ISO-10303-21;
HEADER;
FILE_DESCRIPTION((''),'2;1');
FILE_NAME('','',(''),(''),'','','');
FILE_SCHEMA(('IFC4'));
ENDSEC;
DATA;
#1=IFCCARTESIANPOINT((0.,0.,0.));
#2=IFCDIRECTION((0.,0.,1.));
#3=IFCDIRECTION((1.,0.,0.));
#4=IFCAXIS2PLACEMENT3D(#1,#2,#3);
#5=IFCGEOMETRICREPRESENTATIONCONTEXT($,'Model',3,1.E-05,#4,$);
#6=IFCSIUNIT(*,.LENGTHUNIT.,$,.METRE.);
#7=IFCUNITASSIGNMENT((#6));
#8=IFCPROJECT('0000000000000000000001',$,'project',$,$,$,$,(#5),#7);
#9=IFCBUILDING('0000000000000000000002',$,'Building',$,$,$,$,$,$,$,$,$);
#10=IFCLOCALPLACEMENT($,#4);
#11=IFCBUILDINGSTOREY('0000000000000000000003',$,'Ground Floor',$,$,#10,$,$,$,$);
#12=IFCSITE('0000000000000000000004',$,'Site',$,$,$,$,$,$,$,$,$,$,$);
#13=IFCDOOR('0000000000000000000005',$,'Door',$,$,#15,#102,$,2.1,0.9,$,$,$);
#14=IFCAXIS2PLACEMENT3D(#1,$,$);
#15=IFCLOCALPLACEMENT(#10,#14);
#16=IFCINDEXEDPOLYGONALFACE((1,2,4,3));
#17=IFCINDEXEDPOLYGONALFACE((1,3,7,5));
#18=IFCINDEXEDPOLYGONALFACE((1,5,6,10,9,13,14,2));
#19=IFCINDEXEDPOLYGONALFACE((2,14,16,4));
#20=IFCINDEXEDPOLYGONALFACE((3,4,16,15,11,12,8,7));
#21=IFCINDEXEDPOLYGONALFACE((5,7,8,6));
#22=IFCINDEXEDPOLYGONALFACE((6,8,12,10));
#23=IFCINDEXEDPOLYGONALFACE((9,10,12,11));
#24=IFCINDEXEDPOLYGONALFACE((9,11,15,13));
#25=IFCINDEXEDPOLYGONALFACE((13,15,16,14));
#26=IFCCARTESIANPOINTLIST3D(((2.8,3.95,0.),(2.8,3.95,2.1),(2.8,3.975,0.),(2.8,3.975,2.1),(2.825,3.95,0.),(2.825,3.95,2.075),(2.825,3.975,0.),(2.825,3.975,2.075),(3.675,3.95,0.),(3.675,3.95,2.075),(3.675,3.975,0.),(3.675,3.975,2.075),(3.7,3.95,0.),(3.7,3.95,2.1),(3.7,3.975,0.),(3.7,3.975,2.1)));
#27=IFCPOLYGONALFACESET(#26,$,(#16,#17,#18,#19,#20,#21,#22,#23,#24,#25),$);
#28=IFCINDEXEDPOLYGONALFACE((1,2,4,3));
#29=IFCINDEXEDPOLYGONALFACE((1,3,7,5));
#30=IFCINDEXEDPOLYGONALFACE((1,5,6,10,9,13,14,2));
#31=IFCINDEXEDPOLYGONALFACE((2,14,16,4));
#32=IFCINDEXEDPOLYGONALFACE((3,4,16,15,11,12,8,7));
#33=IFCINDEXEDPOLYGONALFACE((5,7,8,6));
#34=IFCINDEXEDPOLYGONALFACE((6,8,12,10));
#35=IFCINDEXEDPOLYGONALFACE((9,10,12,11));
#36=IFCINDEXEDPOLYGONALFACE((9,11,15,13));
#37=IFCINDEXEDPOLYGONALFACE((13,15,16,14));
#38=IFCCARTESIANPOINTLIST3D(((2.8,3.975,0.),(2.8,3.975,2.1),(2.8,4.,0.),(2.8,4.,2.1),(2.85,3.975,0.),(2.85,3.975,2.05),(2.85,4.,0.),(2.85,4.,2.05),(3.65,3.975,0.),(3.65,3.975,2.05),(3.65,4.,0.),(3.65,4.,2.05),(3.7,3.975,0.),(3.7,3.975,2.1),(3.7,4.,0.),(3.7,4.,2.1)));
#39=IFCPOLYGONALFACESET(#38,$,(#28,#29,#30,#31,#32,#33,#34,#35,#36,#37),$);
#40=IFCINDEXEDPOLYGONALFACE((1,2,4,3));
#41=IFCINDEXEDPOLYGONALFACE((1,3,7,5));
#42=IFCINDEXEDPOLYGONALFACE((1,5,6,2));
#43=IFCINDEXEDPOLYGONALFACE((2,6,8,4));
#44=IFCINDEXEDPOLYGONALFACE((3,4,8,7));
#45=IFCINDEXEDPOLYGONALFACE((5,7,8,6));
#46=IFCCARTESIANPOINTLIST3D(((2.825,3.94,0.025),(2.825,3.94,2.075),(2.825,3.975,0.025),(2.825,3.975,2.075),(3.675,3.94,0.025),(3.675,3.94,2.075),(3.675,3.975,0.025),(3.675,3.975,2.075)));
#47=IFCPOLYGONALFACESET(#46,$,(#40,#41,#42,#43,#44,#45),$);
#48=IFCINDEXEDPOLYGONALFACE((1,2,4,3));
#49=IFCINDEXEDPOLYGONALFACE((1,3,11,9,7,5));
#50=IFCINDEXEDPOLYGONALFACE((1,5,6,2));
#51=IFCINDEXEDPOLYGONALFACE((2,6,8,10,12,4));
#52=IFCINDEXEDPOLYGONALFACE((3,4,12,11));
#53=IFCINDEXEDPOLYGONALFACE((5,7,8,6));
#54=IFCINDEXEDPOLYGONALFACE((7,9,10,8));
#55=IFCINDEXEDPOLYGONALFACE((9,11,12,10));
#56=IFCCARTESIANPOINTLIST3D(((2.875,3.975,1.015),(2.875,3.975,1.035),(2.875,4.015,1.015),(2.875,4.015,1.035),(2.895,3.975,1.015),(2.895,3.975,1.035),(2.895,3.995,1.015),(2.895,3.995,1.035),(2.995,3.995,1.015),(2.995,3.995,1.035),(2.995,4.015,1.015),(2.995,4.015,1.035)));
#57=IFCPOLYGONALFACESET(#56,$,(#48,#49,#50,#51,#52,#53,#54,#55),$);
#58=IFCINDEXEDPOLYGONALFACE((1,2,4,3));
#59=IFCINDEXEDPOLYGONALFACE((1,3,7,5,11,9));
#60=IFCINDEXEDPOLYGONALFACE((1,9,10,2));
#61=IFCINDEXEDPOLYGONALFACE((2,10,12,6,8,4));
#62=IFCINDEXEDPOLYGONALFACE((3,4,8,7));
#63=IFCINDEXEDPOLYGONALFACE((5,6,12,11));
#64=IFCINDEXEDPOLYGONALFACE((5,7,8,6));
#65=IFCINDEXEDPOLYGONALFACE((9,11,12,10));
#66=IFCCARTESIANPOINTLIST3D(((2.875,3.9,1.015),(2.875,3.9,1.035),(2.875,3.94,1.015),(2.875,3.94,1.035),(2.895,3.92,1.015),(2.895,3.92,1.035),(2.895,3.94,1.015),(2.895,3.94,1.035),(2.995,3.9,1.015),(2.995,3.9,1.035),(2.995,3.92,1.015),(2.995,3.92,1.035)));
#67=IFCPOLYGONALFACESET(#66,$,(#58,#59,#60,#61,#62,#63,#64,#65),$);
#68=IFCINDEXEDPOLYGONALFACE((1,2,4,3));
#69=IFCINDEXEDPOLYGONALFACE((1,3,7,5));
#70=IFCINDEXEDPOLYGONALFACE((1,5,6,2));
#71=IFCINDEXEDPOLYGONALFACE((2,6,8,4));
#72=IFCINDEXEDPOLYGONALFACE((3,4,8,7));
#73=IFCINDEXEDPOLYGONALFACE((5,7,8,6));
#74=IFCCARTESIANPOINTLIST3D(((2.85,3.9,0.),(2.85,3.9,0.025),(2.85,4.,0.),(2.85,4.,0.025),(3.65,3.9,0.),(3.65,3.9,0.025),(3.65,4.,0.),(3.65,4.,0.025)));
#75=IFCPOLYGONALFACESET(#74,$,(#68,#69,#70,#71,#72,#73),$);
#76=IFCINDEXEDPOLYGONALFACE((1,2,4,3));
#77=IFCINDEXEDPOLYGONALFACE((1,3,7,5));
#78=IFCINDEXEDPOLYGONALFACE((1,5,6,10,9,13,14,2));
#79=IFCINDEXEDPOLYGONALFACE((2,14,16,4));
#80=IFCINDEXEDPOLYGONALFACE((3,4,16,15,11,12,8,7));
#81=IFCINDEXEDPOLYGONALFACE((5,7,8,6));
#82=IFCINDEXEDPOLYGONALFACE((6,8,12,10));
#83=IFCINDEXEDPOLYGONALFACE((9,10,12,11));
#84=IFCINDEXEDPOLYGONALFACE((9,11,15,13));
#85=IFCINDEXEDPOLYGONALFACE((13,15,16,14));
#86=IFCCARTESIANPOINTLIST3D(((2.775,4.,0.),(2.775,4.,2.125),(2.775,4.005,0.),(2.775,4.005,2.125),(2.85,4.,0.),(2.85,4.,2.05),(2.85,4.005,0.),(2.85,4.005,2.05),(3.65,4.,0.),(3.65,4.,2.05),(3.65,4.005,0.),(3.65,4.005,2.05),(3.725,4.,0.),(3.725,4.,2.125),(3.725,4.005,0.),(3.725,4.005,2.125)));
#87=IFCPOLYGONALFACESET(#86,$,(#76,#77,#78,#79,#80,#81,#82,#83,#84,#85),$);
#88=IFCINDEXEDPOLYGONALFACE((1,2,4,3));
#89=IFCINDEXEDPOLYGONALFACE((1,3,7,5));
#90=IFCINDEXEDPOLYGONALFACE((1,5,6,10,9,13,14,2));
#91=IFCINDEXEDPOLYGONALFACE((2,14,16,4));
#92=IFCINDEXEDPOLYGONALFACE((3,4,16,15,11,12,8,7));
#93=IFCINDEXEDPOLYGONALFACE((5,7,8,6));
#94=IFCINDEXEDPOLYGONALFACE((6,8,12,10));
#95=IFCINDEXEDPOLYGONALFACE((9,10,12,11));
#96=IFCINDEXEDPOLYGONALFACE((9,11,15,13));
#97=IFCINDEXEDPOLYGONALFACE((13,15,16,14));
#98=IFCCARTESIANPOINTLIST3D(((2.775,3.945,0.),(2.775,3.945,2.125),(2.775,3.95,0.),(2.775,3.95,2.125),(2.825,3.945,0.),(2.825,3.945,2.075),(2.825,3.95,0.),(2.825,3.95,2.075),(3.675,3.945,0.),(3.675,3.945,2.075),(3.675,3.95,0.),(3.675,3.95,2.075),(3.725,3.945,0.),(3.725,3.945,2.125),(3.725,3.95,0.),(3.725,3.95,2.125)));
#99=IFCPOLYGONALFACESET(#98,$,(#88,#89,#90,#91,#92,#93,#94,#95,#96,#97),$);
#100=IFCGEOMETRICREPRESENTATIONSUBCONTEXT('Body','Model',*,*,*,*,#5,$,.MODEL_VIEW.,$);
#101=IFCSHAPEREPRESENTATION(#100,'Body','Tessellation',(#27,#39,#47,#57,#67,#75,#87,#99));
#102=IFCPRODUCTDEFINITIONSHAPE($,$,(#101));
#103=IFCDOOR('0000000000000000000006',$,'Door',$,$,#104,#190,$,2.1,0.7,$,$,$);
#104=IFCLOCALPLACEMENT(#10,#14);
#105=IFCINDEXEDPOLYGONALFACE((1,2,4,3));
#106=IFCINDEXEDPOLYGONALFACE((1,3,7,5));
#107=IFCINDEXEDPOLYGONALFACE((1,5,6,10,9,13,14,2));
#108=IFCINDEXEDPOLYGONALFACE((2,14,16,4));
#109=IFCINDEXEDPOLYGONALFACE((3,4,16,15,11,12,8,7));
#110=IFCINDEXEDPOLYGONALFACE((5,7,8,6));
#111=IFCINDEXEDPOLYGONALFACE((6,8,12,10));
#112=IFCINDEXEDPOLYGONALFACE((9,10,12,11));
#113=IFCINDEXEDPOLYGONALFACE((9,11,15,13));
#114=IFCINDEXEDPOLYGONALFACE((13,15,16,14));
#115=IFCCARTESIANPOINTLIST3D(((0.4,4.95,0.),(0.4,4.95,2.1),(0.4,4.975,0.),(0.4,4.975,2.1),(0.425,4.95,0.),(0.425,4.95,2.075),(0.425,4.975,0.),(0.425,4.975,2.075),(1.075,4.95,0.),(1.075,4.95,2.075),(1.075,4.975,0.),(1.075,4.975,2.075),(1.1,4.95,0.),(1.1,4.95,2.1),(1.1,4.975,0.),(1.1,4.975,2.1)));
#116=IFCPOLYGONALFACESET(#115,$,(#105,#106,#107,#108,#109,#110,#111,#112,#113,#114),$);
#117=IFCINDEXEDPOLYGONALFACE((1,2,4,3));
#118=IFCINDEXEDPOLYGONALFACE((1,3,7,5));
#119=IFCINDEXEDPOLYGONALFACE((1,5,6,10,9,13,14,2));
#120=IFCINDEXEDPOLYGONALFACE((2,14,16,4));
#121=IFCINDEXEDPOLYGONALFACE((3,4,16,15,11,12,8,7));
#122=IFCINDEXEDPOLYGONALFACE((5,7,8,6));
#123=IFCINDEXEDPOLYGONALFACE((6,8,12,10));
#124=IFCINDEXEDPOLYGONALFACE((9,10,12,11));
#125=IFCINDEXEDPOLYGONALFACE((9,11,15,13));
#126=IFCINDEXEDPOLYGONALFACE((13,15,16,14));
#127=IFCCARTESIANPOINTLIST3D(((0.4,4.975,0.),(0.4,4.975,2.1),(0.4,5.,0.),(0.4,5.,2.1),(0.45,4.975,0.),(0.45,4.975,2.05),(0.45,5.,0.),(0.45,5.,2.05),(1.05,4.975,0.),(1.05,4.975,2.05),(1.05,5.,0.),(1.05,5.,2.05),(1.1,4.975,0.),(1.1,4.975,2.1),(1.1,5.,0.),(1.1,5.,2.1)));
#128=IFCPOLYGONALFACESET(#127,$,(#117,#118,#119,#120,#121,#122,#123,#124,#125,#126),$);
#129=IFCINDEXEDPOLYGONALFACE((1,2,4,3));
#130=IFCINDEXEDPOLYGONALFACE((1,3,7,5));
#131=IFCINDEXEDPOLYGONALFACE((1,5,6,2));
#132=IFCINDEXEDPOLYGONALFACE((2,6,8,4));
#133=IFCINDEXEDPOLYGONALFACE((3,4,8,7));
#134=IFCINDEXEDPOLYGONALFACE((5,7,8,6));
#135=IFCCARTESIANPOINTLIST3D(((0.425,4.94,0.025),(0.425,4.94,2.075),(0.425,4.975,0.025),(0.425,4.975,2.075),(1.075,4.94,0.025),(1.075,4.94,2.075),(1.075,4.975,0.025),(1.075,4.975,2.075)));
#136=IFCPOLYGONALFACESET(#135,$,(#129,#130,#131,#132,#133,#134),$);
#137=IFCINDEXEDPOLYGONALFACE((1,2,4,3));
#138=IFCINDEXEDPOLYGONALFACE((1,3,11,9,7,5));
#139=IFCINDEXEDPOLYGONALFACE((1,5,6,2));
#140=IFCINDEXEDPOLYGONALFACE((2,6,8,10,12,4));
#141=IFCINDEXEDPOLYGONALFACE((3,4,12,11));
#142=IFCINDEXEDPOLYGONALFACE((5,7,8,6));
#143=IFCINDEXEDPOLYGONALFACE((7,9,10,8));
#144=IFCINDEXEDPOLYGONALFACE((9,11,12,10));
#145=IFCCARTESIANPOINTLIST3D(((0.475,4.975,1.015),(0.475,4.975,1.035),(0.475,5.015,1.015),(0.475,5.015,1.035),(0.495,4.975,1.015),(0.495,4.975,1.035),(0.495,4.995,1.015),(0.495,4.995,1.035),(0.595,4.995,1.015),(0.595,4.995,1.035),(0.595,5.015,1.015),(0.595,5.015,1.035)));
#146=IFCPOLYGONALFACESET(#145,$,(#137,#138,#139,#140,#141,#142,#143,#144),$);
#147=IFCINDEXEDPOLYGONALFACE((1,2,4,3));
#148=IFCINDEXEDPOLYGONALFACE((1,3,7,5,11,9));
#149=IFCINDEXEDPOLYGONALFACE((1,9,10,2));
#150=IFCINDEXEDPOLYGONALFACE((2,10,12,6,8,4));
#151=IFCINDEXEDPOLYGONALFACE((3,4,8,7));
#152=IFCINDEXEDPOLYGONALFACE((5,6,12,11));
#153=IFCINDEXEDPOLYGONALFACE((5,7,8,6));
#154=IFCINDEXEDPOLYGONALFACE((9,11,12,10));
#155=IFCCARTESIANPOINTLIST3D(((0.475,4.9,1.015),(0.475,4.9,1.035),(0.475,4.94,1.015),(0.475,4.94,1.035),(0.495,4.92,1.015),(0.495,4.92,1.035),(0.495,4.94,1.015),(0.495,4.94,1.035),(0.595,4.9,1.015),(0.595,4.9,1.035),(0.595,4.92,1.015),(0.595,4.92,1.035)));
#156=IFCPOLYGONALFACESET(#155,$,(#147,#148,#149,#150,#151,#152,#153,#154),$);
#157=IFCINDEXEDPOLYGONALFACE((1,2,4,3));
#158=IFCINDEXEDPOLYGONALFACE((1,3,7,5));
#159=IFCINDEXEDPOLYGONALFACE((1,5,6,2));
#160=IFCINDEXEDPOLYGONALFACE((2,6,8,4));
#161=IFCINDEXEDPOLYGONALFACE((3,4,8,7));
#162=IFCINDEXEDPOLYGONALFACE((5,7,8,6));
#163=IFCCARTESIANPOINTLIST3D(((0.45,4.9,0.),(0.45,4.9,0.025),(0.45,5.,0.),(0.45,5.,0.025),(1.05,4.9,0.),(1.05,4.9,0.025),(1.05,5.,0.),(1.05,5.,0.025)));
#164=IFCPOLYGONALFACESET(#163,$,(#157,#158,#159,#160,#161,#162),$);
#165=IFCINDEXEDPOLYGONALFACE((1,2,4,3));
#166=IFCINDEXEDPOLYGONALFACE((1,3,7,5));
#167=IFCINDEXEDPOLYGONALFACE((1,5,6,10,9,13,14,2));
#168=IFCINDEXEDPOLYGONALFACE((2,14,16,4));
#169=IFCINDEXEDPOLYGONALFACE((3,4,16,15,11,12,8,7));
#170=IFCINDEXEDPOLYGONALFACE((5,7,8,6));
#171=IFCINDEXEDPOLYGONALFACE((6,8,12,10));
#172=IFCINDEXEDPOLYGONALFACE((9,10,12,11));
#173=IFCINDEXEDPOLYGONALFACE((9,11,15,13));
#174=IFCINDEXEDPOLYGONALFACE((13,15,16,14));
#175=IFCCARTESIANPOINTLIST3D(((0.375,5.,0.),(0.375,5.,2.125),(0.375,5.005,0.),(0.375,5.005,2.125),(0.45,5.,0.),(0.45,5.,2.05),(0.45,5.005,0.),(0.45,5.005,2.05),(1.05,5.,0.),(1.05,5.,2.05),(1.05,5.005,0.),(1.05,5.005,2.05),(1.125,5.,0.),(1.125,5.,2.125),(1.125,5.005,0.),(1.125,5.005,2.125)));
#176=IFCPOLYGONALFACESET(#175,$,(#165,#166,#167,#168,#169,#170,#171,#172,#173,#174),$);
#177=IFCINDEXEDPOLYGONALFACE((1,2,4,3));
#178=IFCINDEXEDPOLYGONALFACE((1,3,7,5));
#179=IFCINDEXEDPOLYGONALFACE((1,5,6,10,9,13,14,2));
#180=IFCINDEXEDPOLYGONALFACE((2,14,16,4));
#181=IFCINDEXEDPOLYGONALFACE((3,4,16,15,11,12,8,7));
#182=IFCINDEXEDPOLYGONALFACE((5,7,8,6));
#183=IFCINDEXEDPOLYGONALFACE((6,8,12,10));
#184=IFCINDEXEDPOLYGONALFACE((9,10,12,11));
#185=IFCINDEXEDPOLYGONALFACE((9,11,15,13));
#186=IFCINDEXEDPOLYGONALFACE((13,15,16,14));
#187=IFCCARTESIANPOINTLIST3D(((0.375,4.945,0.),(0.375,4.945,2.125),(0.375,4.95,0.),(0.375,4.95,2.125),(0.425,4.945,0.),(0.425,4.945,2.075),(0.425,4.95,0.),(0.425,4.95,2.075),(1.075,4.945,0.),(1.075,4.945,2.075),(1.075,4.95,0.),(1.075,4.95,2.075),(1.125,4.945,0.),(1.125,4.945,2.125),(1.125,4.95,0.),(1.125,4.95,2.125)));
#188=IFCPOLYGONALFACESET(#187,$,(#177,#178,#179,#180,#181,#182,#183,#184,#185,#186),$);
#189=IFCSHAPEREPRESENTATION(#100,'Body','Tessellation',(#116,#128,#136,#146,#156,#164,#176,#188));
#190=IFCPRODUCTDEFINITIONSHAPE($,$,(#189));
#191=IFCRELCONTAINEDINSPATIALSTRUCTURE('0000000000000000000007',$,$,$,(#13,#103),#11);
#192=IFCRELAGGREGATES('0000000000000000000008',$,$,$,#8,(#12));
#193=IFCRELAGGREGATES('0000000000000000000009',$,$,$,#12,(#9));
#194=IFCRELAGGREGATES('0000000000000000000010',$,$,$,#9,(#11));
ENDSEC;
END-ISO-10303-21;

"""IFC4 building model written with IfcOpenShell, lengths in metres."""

from ifc_helpers import new_model, si_unit, frame, origin_with_axes, place, context, subcontext, project, spatial, line, indexed_curve, outline, extrude, element, save


model = new_model("IFC4")

# Units and contexts
model_context = context("Model", 3, precision=1e-05, world=origin_with_axes())
body_context = subcontext(model_context, "Body", "Model", "MODEL_VIEW")
ifc_project = project(units=[si_unit("LENGTHUNIT", "METRE")], contexts=[model_context])

# Site, building, storey
site = spatial("IfcSite", under=ifc_project, Name="Site")
building = spatial("IfcBuilding", under=site, Name="Building")
storey_placement = place(None, origin_with_axes())
storey = spatial("IfcBuildingStorey", under=building, at=storey_placement, Name="Ground Floor")

# Doors
door_1_placement = place(storey_placement, frame((3.7, 4.0, 0.0), z_axis=(0.0, 0.0, 1.0), x_axis=(-1.0, 0.0, 0.0)))
element("IfcDoor", 1, at=door_1_placement, inside=storey, Name="Door", OverallHeight=2.1, OverallWidth=0.9, context=body_context, shape_type="SweptSolid", body=[
    extrude(outline(indexed_curve([(0.0, 0.0), (0.0, 2.1), (0.9, 2.1), (0.9, 0.0), (0.875, 0.0), (0.875, 2.075), (0.025, 2.075), (0.025, 0.0)], segments=[line(1, 2, 3, 4, 5, 6, 7, 8, 1)])), frame((0.0, 0.025, 0.0), z_axis=(0.0, -1.0, 0.0), x_axis=(1.0, 0.0, 0.0)), (0.0, 0.0, -1.0), 0.025),
    extrude(outline(indexed_curve([(0.0, 0.0), (0.0, 2.1), (0.9, 2.1), (0.9, 0.0), (0.85, 0.0), (0.85, 2.05), (0.05, 2.05), (0.05, 0.0)], segments=[line(1, 2, 3, 4, 5, 6, 7, 8, 1)])), frame((0.0, 0.0, 0.0), z_axis=(0.0, -1.0, 0.0), x_axis=(1.0, 0.0, 0.0)), (0.0, 0.0, -1.0), 0.025),
    extrude(outline(indexed_curve([(0.0, 0.0), (0.85, 0.0), (0.85, 0.035), (0.0, 0.035)], segments=[line(1, 2, 3, 4, 1)])), frame((0.025, 0.025, 0.025), z_axis=(0.0, 0.0, 1.0), x_axis=(1.0, 0.0, 0.0)), (0.0, 0.0, 1.0), 2.05),
    extrude(outline(indexed_curve([(0.0, 0.0), (0.0, -0.04), (-0.12, -0.04), (-0.12, -0.02), (-0.02, -0.02), (-0.02, 0.0)], segments=[line(1, 2, 3, 4, 5, 6, 1)])), frame((0.825, 0.025, 1.015), z_axis=(0.0, 0.0, 1.0), x_axis=(1.0, 0.0, 0.0)), (0.0, 0.0, 1.0), 0.02),
    extrude(outline(indexed_curve([(0.0, 0.0), (0.0, 0.04), (-0.12, 0.04), (-0.12, 0.02), (-0.02, 0.02), (-0.02, 0.0)], segments=[line(1, 2, 3, 4, 5, 6, 1)])), frame((0.825, 0.06, 1.015), z_axis=(0.0, 0.0, 1.0), x_axis=(1.0, 0.0, 0.0)), (0.0, 0.0, 1.0), 0.02),
    extrude(outline(indexed_curve([(0.0, 0.0), (0.8, 0.0), (0.8, 0.1), (0.0, 0.1)], segments=[line(1, 2, 3, 4, 1)])), frame((0.05, 0.0, 0.0), z_axis=(0.0, 0.0, 1.0), x_axis=(1.0, 0.0, 0.0)), (0.0, 0.0, 1.0), 0.025),
    extrude(outline(indexed_curve([(0.0, 0.0), (0.0, 2.125), (0.95, 2.125), (0.95, 0.0), (0.875, 0.0), (0.875, 2.05), (0.075, 2.05), (0.075, 0.0)], segments=[line(1, 2, 3, 4, 5, 6, 7, 8, 1)])), frame((-0.025, -0.005, 0.0), z_axis=(0.0, -1.0, 0.0), x_axis=(1.0, 0.0, 0.0)), (0.0, 0.0, -1.0), 0.005),
    extrude(outline(indexed_curve([(0.0, 0.0), (0.0, 2.125), (0.95, 2.125), (0.95, 0.0), (0.9, 0.0), (0.9, 2.075), (0.05, 2.075), (0.05, 0.0)], segments=[line(1, 2, 3, 4, 5, 6, 7, 8, 1)])), frame((-0.025, 0.05, 0.0), z_axis=(0.0, -1.0, 0.0), x_axis=(1.0, 0.0, 0.0)), (0.0, 0.0, -1.0), 0.005),
])
door_2_placement = place(storey_placement, frame((1.1, 5.0, 0.0), z_axis=(0.0, 0.0, 1.0), x_axis=(-1.0, 0.0, 0.0)))
element("IfcDoor", 2, at=door_2_placement, inside=storey, Name="Door", OverallHeight=2.1, OverallWidth=0.7, context=body_context, shape_type="SweptSolid", body=[
    extrude(outline(indexed_curve([(0.0, 0.0), (0.0, 2.1), (0.7, 2.1), (0.7, 0.0), (0.675, 0.0), (0.675, 2.075), (0.025, 2.075), (0.025, 0.0)], segments=[line(1, 2, 3, 4, 5, 6, 7, 8, 1)])), frame((0.0, 0.025, 0.0), z_axis=(0.0, -1.0, 0.0), x_axis=(1.0, 0.0, 0.0)), (0.0, 0.0, -1.0), 0.025),
    extrude(outline(indexed_curve([(0.0, 0.0), (0.0, 2.1), (0.7, 2.1), (0.7, 0.0), (0.65, 0.0), (0.65, 2.05), (0.05, 2.05), (0.05, 0.0)], segments=[line(1, 2, 3, 4, 5, 6, 7, 8, 1)])), frame((0.0, 0.0, 0.0), z_axis=(0.0, -1.0, 0.0), x_axis=(1.0, 0.0, 0.0)), (0.0, 0.0, -1.0), 0.025),
    extrude(outline(indexed_curve([(0.0, 0.0), (0.65, 0.0), (0.65, 0.035), (0.0, 0.035)], segments=[line(1, 2, 3, 4, 1)])), frame((0.025, 0.025, 0.025), z_axis=(0.0, 0.0, 1.0), x_axis=(1.0, 0.0, 0.0)), (0.0, 0.0, 1.0), 2.05),
    extrude(outline(indexed_curve([(0.0, 0.0), (0.0, -0.04), (-0.12, -0.04), (-0.12, -0.02), (-0.02, -0.02), (-0.02, 0.0)], segments=[line(1, 2, 3, 4, 5, 6, 1)])), frame((0.625, 0.025, 1.015), z_axis=(0.0, 0.0, 1.0), x_axis=(1.0, 0.0, 0.0)), (0.0, 0.0, 1.0), 0.02),
    extrude(outline(indexed_curve([(0.0, 0.0), (0.0, 0.04), (-0.12, 0.04), (-0.12, 0.02), (-0.02, 0.02), (-0.02, 0.0)], segments=[line(1, 2, 3, 4, 5, 6, 1)])), frame((0.625, 0.06, 1.015), z_axis=(0.0, 0.0, 1.0), x_axis=(1.0, 0.0, 0.0)), (0.0, 0.0, 1.0), 0.02),
    extrude(outline(indexed_curve([(0.0, 0.0), (0.6, 0.0), (0.6, 0.1), (0.0, 0.1)], segments=[line(1, 2, 3, 4, 1)])), frame((0.05, 0.0, 0.0), z_axis=(0.0, 0.0, 1.0), x_axis=(1.0, 0.0, 0.0)), (0.0, 0.0, 1.0), 0.025),
    extrude(outline(indexed_curve([(0.0, 0.0), (0.0, 2.125), (0.75, 2.125), (0.75, 0.0), (0.675, 0.0), (0.675, 2.05), (0.075, 2.05), (0.075, 0.0)], segments=[line(1, 2, 3, 4, 5, 6, 7, 8, 1)])), frame((-0.025, -0.005, 0.0), z_axis=(0.0, -1.0, 0.0), x_axis=(1.0, 0.0, 0.0)), (0.0, 0.0, -1.0), 0.005),
    extrude(outline(indexed_curve([(0.0, 0.0), (0.0, 2.125), (0.75, 2.125), (0.75, 0.0), (0.7, 0.0), (0.7, 2.075), (0.05, 2.075), (0.05, 0.0)], segments=[line(1, 2, 3, 4, 5, 6, 7, 8, 1)])), frame((-0.025, 0.05, 0.0), z_axis=(0.0, -1.0, 0.0), x_axis=(1.0, 0.0, 0.0)), (0.0, 0.0, -1.0), 0.005),
])

save(model, "model.ifc")
